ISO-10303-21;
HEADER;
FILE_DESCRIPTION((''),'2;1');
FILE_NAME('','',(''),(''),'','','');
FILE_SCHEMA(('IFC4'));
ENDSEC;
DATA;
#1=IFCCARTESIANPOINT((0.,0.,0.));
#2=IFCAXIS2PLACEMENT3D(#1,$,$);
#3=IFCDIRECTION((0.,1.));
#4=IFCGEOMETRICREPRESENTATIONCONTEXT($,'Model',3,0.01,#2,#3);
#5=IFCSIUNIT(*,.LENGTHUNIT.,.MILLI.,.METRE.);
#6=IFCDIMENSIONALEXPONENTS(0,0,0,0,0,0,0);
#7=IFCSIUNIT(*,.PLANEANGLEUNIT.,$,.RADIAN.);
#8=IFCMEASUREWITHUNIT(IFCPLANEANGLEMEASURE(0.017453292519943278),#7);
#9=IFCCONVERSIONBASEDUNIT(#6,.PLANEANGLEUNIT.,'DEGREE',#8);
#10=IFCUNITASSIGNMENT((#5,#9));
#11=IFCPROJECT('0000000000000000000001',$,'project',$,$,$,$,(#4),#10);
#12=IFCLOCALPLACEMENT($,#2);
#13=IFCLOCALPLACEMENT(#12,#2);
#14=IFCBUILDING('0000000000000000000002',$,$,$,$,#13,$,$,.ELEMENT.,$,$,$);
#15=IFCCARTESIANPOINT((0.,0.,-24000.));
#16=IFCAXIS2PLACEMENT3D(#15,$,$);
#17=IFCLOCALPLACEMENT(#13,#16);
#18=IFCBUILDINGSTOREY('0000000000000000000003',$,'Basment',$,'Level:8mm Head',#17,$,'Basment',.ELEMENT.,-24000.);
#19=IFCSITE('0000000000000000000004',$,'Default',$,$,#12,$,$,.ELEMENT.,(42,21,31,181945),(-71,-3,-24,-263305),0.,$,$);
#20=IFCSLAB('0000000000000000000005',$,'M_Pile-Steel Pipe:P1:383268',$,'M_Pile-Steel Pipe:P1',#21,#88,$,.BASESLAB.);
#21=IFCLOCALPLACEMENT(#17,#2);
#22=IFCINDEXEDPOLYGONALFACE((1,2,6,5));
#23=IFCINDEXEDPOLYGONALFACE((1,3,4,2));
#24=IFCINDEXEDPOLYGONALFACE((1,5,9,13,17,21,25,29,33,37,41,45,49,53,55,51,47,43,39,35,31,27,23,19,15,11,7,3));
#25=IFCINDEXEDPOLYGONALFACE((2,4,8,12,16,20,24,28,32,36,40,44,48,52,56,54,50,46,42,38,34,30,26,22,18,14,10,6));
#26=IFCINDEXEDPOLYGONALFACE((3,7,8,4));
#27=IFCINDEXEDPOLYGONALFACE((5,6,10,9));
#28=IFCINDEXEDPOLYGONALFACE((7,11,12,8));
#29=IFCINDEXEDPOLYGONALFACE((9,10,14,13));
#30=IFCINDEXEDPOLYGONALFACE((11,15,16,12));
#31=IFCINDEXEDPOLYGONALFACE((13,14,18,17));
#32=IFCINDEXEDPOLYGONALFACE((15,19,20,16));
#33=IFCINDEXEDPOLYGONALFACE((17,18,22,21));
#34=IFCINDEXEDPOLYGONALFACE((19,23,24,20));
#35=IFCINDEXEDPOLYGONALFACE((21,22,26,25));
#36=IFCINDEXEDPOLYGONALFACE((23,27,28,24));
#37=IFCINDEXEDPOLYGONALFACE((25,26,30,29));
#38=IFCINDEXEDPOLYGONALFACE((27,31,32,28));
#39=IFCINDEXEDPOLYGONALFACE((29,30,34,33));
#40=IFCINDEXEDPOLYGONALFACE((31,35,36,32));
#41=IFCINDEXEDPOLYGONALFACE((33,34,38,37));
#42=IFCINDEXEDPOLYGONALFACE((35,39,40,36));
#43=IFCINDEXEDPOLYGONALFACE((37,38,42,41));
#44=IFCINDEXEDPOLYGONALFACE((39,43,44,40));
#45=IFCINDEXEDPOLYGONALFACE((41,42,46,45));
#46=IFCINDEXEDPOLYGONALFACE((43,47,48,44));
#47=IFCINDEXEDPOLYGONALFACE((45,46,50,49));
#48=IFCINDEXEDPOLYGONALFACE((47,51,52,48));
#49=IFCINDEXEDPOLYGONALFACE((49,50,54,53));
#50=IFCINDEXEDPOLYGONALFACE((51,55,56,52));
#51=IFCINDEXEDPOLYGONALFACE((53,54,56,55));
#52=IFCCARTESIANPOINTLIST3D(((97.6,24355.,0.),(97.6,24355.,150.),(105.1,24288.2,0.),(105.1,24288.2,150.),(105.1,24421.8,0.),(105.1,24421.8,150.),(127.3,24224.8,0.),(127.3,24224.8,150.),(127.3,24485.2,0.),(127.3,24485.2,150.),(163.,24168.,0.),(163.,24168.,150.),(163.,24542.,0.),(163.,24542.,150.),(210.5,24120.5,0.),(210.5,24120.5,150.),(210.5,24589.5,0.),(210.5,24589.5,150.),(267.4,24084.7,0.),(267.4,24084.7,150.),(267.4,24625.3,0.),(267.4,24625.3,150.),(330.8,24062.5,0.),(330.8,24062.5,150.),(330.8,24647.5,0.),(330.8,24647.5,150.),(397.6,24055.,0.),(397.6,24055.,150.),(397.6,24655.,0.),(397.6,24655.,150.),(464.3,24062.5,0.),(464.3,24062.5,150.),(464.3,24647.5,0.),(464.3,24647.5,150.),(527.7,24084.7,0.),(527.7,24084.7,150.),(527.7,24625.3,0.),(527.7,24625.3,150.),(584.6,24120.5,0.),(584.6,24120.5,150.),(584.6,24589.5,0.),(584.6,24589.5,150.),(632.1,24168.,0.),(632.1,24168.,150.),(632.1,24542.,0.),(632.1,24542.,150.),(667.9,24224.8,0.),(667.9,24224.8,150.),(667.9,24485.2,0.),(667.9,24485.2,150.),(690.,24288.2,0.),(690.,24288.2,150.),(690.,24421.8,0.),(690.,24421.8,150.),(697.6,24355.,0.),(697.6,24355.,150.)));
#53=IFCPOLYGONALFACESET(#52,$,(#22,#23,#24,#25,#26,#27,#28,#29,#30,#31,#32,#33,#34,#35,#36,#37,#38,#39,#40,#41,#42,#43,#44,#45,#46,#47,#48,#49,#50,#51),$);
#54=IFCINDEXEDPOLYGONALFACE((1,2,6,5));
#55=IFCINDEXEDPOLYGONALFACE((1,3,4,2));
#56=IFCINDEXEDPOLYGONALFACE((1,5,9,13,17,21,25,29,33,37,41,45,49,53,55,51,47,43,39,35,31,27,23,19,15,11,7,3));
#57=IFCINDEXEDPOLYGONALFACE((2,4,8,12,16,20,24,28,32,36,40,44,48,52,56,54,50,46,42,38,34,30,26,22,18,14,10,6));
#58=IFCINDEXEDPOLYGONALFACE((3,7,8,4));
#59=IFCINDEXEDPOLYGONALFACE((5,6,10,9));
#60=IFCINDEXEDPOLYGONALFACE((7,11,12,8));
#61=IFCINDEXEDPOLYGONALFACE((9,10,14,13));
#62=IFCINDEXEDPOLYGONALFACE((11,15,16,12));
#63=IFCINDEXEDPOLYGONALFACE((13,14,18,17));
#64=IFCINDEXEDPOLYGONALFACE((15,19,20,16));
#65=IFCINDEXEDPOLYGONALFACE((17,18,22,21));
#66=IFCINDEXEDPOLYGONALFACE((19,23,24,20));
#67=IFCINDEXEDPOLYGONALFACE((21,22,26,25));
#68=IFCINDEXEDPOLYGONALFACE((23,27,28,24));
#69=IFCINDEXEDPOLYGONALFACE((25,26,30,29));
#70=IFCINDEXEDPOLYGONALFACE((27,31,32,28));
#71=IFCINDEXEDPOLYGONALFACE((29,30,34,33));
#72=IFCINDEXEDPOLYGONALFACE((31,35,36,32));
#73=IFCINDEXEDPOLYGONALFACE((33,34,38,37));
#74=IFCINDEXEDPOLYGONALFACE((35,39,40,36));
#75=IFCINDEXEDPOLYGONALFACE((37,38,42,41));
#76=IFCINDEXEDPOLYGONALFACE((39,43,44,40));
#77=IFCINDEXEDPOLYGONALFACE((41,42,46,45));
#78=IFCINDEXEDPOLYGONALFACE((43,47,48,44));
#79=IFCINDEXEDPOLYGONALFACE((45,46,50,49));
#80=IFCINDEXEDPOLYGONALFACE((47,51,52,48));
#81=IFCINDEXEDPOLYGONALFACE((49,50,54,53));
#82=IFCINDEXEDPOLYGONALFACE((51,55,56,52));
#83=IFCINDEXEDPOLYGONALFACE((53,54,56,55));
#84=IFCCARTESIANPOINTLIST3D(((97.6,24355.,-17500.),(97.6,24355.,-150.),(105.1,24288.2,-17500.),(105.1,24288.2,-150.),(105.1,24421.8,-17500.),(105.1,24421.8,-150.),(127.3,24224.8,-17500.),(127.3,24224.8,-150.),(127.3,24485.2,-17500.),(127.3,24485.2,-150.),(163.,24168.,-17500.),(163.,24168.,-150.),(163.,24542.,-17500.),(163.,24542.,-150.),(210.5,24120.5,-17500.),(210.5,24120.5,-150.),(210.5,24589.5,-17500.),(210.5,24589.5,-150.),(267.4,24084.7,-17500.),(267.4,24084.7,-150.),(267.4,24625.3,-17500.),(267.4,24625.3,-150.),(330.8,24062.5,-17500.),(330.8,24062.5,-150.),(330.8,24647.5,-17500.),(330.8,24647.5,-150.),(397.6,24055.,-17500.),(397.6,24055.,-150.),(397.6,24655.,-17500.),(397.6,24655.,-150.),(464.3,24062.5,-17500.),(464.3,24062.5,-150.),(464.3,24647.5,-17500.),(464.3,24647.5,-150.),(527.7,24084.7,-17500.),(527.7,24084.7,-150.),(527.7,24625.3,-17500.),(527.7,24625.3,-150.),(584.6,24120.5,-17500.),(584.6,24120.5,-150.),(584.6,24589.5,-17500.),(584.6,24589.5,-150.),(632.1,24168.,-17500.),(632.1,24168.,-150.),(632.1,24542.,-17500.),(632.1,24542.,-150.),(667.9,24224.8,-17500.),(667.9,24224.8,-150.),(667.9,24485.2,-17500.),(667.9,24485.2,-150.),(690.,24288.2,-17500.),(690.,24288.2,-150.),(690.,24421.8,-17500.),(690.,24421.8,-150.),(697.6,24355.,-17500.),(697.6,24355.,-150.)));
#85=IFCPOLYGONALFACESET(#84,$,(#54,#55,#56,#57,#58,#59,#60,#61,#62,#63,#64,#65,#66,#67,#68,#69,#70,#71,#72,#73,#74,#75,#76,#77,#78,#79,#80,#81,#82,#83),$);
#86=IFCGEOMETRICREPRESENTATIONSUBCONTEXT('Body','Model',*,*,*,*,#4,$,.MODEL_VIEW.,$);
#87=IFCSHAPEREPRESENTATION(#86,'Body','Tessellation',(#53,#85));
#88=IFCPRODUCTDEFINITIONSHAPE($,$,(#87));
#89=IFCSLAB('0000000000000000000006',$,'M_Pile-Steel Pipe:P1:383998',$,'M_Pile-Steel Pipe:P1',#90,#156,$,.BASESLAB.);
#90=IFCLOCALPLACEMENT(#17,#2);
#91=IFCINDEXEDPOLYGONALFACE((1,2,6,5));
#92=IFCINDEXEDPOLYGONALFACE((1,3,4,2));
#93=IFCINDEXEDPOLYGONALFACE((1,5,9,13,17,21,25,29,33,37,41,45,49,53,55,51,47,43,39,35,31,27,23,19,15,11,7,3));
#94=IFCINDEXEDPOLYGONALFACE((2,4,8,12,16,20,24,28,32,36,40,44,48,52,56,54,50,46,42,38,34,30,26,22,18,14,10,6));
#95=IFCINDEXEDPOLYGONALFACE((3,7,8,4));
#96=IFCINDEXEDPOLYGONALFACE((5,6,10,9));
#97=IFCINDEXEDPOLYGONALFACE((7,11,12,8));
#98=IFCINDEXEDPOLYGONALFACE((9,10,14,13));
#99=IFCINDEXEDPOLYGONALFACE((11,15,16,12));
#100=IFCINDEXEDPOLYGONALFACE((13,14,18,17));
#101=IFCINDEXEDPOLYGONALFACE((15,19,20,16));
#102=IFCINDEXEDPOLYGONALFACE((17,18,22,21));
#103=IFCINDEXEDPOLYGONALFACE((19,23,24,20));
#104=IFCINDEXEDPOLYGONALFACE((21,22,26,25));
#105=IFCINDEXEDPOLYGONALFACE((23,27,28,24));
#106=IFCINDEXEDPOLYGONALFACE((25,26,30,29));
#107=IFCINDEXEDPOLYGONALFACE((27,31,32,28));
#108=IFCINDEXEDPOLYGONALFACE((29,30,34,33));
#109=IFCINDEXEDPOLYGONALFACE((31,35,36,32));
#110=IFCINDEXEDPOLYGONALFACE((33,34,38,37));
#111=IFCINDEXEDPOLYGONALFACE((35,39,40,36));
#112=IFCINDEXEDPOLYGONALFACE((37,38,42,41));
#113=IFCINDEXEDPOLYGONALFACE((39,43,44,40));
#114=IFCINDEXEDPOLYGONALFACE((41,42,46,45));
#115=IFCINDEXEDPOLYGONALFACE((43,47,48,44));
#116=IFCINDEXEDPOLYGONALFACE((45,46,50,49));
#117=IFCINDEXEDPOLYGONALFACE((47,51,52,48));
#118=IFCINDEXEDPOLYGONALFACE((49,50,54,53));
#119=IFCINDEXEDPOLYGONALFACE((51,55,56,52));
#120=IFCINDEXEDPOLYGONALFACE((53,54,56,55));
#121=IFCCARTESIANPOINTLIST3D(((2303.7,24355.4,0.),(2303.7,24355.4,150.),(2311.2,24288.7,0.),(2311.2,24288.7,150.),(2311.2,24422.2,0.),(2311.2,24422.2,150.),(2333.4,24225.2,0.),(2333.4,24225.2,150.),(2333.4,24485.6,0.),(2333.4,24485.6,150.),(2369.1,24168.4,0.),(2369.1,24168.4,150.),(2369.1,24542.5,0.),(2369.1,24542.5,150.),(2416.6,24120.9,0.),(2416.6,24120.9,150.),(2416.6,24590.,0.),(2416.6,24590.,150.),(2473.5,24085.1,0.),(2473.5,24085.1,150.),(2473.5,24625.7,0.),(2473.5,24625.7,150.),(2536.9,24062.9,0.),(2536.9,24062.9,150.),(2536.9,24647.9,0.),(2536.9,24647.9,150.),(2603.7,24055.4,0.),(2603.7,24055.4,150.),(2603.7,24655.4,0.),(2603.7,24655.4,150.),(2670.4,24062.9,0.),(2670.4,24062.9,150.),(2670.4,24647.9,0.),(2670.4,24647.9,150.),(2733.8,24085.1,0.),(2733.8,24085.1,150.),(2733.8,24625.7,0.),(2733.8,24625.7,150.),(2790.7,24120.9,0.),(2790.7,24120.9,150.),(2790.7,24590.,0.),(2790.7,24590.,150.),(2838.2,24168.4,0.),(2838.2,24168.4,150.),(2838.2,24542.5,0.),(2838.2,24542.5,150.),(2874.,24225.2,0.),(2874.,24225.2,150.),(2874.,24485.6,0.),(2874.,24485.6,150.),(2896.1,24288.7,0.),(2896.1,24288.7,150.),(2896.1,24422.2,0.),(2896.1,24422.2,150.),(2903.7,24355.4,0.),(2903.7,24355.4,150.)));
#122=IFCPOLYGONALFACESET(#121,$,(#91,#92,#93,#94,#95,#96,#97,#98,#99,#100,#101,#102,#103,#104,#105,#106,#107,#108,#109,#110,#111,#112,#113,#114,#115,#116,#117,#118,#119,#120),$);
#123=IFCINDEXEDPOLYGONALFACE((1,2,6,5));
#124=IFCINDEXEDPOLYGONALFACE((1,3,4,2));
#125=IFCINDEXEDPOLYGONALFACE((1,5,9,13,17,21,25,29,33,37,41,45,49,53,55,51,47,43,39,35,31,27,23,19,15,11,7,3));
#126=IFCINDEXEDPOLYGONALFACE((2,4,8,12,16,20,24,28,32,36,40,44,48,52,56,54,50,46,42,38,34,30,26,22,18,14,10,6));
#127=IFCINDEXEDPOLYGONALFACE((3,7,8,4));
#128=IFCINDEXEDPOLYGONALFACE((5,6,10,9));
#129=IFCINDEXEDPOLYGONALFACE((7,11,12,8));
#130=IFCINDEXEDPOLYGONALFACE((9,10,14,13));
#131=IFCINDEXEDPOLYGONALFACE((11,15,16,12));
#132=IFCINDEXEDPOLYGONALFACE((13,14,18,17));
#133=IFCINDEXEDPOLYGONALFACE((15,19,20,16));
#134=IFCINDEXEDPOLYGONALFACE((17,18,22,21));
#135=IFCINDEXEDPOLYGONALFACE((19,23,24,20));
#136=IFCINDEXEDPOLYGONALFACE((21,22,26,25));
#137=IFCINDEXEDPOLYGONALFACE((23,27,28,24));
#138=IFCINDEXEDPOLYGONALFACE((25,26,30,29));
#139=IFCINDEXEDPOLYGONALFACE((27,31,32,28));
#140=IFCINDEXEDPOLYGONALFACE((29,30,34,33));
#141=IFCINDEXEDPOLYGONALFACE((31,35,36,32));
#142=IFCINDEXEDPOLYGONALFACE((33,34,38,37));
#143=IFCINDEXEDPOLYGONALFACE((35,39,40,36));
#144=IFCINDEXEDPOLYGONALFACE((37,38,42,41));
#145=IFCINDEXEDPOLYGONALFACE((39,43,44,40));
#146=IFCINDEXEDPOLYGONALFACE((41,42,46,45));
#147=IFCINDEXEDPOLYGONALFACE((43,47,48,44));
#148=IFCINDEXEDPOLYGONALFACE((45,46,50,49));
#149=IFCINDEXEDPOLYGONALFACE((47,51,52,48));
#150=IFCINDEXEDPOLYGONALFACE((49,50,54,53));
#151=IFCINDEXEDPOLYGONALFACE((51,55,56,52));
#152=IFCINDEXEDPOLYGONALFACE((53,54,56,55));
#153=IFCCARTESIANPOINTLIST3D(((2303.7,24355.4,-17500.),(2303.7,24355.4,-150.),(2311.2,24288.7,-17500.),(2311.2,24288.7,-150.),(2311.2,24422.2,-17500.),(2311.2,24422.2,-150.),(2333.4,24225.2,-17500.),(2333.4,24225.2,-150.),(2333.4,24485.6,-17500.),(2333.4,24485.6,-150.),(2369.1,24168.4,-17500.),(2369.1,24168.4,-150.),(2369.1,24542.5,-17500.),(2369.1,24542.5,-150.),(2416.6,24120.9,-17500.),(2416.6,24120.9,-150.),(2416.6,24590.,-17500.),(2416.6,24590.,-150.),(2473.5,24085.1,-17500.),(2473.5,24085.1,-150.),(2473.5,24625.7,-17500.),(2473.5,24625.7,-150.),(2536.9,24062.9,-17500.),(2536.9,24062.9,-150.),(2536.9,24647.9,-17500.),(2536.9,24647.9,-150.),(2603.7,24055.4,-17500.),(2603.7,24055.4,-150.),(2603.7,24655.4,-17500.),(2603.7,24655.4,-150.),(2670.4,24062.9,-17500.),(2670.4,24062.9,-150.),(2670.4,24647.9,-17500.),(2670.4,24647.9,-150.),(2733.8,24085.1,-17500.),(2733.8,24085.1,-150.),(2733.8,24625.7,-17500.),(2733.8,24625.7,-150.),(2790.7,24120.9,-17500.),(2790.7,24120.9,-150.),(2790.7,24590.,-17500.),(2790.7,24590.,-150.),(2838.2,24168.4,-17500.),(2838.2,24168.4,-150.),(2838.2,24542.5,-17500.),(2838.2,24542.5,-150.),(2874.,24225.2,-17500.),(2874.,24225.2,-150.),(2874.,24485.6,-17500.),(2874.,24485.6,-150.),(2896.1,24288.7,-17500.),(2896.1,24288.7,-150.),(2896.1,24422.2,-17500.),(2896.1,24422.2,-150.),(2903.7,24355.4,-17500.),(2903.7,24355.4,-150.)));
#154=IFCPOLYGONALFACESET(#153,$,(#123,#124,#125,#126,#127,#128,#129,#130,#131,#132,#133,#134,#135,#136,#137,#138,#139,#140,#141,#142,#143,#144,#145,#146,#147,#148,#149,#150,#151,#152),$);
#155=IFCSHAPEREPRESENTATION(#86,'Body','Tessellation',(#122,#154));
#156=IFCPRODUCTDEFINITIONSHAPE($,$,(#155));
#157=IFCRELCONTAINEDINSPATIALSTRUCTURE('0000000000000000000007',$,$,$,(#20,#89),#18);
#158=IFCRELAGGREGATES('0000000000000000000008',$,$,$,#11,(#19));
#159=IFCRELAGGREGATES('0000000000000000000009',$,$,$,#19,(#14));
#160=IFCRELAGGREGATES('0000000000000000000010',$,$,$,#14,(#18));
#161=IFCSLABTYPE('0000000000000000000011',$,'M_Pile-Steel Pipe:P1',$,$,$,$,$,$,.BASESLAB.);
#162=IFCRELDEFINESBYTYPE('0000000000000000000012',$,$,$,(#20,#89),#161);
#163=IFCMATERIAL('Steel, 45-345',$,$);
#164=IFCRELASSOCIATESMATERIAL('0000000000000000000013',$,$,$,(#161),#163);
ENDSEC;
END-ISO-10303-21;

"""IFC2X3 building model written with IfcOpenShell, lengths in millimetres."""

from ifc_helpers import new_model, entity, si_unit, converted_unit, direction, frame, frame_2d, origin, place, context, subcontext, project, spatial, circle, extrude, material, type_object, element, save


model = new_model("IFC2X3")

# Units and contexts
model_context = context("Model", 3, precision=0.01, world=origin(), true_north=direction((0.0, 1.0)))
body_context = subcontext(model_context, "Body", "Model", "MODEL_VIEW")
ifc_project = project(units=[si_unit("LENGTHUNIT", "METRE", prefix="MILLI"), converted_unit("PLANEANGLEUNIT", "DEGREE", entity("IfcPlaneAngleMeasure", 0.017453292519943278), si_unit("PLANEANGLEUNIT", "RADIAN"), dimensions=[0, 0, 0, 0, 0, 0, 0])], contexts=[model_context])

# Site, building, storey
site_placement = place(None, origin())
site = spatial("IfcSite", under=ifc_project, at=site_placement, Name="Default", CompositionType="ELEMENT", RefLatitude=(42, 21, 31, 181945), RefLongitude=(-71, -3, -24, -263305), RefElevation=0.0)
building_placement = place(site_placement, origin())
building = spatial("IfcBuilding", under=site, at=building_placement, CompositionType="ELEMENT")
storey_placement = place(building_placement, frame((0.0, 0.0, -24000.0)))
storey = spatial("IfcBuildingStorey", under=building, at=storey_placement, Name="Basment", ObjectType="Level:8mm Head", LongName="Basment", CompositionType="ELEMENT", Elevation=-24000.0)

# Slabs
ifc_material_1 = material(Name="Steel, 45-345")
slab_type_1 = type_object("IfcSlabType", Name="M_Pile-Steel Pipe:P1", PredefinedType="BASESLAB", material=ifc_material_1)
slab_1_placement = place(storey_placement, origin())
element("IfcSlab", 1, at=slab_1_placement, inside=storey, type_object=slab_type_1, Name="M_Pile-Steel Pipe:P1:383268", ObjectType="M_Pile-Steel Pipe:P1", PredefinedType="BASESLAB", context=body_context, shape_type="SweptSolid", body=[
    extrude(circle(Radius=300.0, at=frame_2d((0.0, 0.0), x_axis=(1.0, 0.0))), frame((397.6, 24355.0, 0.0), z_axis=(0.0, 0.0, 1.0), x_axis=(0.0, 1.0, 0.0)), (0.0, 0.0, 1.0), 150.0),
    extrude(circle(Radius=300.0, at=frame_2d((0.0, 0.0), x_axis=(1.0, 0.0))), frame((397.6, 24355.0, -17500.0), z_axis=(0.0, 0.0, 1.0), x_axis=(0.0, 1.0, 0.0)), (0.0, 0.0, 1.0), 17350.0),
])
slab_2_placement = place(storey_placement, origin())
element("IfcSlab", 2, at=slab_2_placement, inside=storey, type_object=slab_type_1, Name="M_Pile-Steel Pipe:P1:383998", ObjectType="M_Pile-Steel Pipe:P1", PredefinedType="BASESLAB", context=body_context, shape_type="SweptSolid", body=[
    extrude(circle(Radius=300.0, at=frame_2d((0.0, 0.0), x_axis=(1.0, 0.0))), frame((2603.7, 24355.4, 0.0), z_axis=(0.0, 0.0, 1.0), x_axis=(0.0, -1.0, 0.0)), (0.0, 0.0, 1.0), 150.0),
    extrude(circle(Radius=300.0, at=frame_2d((0.0, 0.0), x_axis=(1.0, 0.0))), frame((2603.7, 24355.4, -17500.0), z_axis=(0.0, 0.0, 1.0), x_axis=(0.0, -1.0, 0.0)), (0.0, 0.0, 1.0), 17350.0),
])

save(model, "model.ifc")
